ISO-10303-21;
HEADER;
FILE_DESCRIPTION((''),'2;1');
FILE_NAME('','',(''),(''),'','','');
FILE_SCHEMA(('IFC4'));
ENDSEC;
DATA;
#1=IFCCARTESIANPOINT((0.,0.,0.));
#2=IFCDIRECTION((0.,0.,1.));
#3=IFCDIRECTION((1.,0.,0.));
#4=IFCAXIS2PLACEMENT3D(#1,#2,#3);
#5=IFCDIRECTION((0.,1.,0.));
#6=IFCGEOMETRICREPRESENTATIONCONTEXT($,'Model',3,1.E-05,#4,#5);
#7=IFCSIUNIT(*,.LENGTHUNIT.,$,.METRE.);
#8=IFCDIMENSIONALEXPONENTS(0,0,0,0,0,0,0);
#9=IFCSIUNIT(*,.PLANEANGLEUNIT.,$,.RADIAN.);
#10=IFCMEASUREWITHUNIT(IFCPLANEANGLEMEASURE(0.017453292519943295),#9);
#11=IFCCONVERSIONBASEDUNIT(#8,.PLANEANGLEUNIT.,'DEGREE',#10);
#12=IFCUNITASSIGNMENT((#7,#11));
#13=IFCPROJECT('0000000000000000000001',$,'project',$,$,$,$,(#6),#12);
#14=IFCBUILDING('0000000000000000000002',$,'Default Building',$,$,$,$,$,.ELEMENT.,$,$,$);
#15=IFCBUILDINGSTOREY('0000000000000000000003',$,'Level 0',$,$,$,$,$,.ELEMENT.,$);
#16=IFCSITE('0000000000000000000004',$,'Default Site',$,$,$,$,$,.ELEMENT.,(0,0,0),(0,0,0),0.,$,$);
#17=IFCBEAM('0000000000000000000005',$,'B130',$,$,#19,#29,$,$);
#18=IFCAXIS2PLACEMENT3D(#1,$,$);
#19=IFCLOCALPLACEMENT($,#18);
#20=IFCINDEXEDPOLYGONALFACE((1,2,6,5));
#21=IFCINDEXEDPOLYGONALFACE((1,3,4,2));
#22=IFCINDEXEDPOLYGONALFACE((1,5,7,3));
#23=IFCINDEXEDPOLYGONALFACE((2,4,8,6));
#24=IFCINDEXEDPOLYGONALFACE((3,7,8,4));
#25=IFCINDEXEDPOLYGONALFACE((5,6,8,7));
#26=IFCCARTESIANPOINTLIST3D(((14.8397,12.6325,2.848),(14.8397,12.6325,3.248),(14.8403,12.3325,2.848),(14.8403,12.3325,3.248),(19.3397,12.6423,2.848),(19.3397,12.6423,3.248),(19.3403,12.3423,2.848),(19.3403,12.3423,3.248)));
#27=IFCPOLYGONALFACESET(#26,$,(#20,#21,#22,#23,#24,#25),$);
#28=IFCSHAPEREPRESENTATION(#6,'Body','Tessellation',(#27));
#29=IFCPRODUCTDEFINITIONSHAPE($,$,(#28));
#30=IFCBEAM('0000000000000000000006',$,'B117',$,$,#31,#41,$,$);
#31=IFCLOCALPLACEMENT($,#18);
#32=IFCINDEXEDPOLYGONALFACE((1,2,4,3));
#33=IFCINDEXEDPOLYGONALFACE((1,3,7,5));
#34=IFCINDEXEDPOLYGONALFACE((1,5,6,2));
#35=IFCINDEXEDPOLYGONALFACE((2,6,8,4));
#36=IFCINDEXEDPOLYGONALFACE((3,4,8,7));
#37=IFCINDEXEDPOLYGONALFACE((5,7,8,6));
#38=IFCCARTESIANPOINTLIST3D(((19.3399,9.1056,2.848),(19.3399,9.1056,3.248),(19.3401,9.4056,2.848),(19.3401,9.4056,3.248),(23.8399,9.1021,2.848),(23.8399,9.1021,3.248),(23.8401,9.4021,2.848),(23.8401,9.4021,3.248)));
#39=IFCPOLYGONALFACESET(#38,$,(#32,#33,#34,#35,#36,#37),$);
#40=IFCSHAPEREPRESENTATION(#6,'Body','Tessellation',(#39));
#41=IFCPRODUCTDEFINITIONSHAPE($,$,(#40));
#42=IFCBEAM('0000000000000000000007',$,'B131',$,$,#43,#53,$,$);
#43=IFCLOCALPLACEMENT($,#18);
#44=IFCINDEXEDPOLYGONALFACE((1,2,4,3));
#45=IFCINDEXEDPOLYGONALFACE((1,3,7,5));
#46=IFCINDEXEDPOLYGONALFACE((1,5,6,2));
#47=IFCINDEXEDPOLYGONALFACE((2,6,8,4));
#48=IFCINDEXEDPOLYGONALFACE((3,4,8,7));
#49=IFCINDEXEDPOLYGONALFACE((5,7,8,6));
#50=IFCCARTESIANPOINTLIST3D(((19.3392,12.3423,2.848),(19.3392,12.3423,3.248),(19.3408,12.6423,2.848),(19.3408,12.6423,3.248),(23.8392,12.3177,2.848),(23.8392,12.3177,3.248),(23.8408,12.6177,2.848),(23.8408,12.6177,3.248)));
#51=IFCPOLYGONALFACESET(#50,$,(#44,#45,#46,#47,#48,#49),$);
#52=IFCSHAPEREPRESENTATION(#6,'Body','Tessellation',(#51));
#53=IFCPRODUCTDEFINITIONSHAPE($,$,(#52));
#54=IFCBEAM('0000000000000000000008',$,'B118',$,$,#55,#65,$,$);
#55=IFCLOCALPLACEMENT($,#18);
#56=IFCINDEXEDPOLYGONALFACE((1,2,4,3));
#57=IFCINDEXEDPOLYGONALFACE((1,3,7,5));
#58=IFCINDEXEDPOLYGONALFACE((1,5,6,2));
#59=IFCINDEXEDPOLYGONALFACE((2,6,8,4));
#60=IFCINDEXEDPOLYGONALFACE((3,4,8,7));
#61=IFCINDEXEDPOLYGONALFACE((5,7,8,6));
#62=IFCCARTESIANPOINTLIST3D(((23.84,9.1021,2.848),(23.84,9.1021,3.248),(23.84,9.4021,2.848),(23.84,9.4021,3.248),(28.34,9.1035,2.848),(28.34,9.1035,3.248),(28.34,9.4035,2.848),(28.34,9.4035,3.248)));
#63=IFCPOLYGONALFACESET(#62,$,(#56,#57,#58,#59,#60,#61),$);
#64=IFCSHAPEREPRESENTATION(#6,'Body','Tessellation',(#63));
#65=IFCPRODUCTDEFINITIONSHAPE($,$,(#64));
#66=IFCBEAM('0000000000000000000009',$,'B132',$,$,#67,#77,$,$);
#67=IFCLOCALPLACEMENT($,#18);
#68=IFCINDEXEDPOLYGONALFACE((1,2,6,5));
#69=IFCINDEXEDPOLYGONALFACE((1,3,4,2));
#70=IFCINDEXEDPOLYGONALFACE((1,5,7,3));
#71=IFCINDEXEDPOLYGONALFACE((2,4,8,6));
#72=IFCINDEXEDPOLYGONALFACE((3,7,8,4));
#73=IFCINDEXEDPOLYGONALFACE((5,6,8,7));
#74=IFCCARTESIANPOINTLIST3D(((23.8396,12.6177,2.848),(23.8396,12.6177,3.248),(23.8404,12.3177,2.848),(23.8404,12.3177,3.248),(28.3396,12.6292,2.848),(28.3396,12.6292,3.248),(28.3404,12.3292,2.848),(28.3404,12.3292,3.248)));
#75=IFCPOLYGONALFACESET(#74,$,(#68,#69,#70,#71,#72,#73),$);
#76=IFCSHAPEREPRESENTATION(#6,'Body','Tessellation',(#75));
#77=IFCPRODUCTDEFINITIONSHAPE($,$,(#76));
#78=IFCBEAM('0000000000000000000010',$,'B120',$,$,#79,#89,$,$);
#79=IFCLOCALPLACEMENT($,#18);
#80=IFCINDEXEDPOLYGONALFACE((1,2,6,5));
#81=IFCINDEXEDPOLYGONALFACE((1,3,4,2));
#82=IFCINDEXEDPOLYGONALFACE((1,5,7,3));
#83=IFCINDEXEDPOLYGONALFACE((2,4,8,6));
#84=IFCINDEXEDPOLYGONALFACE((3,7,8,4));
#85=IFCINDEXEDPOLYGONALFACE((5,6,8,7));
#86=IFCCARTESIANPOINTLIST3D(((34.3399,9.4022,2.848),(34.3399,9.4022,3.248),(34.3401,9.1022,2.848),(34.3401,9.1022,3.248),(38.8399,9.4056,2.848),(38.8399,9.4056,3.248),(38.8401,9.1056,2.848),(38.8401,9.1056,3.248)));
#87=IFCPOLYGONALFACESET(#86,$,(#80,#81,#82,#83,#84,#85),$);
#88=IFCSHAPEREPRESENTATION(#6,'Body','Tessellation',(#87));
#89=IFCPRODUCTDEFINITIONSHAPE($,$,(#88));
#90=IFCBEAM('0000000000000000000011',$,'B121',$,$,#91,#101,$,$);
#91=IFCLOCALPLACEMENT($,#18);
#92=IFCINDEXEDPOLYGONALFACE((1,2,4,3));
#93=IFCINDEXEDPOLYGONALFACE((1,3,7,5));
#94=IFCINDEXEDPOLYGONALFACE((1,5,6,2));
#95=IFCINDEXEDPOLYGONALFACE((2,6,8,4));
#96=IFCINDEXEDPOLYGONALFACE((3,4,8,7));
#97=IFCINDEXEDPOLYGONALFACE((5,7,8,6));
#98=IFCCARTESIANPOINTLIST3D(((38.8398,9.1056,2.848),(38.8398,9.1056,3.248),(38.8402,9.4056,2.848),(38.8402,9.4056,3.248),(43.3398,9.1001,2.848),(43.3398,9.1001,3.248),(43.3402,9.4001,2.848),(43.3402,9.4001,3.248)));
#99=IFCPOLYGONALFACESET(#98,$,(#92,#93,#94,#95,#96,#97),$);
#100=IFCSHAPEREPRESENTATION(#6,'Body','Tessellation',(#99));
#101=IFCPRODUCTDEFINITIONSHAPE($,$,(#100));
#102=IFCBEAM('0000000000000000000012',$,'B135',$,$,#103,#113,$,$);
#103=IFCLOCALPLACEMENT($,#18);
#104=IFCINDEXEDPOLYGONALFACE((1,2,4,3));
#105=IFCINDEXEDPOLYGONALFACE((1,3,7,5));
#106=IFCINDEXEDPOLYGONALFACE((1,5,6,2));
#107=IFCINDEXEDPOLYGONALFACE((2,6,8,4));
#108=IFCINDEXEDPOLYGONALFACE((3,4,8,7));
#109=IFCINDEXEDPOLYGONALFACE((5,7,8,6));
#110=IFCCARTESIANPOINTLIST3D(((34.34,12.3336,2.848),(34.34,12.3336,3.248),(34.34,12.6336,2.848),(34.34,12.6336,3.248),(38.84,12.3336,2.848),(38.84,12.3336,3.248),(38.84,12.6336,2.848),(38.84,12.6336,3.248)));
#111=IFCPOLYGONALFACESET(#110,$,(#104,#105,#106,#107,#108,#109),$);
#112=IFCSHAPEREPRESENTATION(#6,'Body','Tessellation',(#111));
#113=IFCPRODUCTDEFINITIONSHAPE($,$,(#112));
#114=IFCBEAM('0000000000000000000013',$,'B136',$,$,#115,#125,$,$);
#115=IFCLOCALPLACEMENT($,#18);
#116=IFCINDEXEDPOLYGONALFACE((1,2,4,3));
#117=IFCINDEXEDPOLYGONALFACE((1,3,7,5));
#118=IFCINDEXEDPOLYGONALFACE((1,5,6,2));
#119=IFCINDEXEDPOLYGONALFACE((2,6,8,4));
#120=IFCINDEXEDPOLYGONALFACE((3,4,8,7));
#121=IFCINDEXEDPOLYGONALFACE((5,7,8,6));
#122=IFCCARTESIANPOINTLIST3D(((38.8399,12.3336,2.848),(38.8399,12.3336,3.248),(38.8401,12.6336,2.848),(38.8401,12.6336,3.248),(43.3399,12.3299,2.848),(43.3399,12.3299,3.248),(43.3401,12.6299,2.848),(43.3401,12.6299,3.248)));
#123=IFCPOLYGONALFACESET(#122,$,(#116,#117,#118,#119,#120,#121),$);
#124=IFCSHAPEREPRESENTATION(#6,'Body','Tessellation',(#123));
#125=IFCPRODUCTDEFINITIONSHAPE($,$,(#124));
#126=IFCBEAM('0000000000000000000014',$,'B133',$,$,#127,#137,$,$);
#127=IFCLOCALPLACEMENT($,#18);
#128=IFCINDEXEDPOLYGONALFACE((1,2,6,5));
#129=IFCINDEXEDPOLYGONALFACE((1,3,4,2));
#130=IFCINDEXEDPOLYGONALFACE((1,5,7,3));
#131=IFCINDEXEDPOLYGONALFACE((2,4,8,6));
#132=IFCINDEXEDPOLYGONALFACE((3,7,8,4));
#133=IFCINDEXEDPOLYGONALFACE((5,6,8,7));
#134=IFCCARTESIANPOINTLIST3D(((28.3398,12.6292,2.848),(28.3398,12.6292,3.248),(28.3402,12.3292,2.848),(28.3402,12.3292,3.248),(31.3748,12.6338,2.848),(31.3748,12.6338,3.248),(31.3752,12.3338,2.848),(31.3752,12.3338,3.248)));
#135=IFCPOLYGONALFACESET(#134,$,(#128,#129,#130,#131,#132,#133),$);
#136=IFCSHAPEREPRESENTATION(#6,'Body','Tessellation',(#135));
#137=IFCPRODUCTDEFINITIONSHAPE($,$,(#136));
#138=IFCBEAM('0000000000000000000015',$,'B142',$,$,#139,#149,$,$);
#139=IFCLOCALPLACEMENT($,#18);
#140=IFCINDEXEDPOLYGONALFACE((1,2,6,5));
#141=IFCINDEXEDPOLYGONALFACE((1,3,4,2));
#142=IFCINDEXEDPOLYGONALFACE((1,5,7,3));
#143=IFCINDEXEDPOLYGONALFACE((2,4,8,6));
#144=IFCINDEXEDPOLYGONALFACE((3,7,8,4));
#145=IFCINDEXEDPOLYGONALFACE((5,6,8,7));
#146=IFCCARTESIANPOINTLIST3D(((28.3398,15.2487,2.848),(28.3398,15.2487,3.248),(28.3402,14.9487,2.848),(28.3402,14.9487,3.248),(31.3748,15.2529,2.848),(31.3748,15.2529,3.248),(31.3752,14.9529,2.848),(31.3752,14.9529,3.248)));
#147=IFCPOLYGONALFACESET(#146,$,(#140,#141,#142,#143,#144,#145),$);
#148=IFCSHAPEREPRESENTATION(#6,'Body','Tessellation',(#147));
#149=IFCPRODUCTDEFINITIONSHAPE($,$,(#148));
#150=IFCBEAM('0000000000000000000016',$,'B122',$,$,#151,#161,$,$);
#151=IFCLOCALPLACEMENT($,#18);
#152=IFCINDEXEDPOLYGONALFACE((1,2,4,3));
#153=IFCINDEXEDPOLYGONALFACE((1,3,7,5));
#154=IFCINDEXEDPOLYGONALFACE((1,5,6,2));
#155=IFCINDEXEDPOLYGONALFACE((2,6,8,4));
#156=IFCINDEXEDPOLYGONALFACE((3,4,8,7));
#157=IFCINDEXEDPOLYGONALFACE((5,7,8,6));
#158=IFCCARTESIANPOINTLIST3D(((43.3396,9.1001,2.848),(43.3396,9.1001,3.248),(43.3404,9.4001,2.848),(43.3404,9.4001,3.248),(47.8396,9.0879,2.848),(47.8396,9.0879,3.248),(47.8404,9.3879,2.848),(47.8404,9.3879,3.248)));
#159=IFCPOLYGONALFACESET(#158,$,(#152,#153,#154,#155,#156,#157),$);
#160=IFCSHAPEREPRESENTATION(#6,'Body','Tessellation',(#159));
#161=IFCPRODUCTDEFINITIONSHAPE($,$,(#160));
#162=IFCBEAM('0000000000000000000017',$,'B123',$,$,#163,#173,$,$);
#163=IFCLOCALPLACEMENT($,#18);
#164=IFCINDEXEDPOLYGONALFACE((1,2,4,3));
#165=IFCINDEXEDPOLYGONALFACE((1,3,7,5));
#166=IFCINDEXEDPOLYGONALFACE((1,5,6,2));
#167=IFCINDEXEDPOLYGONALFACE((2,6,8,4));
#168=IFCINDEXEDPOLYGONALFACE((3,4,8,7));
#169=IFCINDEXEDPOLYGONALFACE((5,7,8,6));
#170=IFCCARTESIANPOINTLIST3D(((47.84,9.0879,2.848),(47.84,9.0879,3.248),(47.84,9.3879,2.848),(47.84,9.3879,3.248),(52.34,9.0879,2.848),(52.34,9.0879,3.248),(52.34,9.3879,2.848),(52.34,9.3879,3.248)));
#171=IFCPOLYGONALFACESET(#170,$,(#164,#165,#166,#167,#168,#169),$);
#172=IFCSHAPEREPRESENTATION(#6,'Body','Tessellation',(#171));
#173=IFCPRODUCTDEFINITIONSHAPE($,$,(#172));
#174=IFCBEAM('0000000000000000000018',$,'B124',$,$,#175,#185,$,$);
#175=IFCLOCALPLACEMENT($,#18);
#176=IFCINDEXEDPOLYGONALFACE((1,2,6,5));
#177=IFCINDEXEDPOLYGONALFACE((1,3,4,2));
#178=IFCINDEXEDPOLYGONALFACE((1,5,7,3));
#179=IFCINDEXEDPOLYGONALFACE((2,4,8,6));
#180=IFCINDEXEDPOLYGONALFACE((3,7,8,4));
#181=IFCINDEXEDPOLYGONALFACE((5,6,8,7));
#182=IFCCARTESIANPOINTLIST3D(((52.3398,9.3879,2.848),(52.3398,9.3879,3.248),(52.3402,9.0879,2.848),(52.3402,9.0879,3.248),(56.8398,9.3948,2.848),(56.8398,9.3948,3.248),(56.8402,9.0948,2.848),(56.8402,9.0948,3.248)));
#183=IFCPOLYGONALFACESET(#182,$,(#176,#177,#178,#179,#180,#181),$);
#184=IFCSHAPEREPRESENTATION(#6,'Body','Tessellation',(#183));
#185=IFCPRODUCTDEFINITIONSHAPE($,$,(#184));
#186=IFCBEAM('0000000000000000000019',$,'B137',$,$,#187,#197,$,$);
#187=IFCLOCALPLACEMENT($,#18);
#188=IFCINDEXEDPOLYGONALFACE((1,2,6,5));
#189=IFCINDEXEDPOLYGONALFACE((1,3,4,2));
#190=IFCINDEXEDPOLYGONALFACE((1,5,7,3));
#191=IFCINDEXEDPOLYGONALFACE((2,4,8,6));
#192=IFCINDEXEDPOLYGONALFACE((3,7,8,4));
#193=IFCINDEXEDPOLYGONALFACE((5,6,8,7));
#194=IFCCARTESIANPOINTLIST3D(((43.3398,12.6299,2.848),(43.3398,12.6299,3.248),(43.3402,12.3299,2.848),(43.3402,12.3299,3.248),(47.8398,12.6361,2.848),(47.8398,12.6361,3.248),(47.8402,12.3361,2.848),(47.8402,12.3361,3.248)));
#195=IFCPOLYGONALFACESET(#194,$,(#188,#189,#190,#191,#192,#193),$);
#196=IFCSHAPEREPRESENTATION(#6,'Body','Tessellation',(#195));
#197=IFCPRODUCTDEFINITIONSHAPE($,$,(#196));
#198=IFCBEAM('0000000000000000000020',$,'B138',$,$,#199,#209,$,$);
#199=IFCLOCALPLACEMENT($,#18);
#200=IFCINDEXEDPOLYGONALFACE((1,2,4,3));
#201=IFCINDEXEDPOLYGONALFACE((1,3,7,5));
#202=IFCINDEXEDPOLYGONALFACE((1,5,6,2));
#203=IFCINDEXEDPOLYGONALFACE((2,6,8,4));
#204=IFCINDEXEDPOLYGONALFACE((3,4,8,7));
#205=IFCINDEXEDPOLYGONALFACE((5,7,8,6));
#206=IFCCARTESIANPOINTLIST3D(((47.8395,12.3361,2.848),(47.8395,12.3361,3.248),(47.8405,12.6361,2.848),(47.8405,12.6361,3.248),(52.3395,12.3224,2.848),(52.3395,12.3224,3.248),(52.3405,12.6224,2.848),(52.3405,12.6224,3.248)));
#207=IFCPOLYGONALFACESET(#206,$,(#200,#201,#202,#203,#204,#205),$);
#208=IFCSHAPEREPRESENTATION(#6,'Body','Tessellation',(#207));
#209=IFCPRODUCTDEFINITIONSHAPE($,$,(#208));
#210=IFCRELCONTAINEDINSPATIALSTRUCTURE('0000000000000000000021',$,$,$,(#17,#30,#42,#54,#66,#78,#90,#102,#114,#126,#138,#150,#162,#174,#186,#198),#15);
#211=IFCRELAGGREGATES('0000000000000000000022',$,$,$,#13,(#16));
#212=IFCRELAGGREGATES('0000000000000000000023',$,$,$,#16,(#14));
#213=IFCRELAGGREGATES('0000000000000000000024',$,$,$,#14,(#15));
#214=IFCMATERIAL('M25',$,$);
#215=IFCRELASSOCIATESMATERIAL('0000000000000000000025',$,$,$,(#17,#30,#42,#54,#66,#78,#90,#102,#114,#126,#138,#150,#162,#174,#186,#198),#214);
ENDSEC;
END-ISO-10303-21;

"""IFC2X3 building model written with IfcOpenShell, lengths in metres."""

from ifc_helpers import new_model, entity, si_unit, converted_unit, direction, frame, frame_2d, origin_with_axes, place, context, project, spatial, rectangle, extrude, material, element, save


model = new_model("IFC2X3")

# Units and contexts
model_context = context("Model", 3, precision=1e-05, world=origin_with_axes(), true_north=direction((0.0, 1.0, 0.0)))
ifc_project = project(units=[si_unit("LENGTHUNIT", "METRE"), converted_unit("PLANEANGLEUNIT", "DEGREE", entity("IfcPlaneAngleMeasure", 0.017453292519943295), si_unit("PLANEANGLEUNIT", "RADIAN"), dimensions=[0, 0, 0, 0, 0, 0, 0])], contexts=[model_context])

# Site, building, storey
site = spatial("IfcSite", under=ifc_project, Name="Default Site", CompositionType="ELEMENT", RefLatitude=(0, 0, 0), RefLongitude=(0, 0, 0), RefElevation=0.0)
building = spatial("IfcBuilding", under=site, Name="Default Building", CompositionType="ELEMENT")
storey = spatial("IfcBuildingStorey", under=building, Name="Level 0", CompositionType="ELEMENT")

# Beams
ifc_material = material(Name="M25")
placement = place(None, origin_with_axes())
element("IfcBeam", 1, at=placement, inside=storey, material=ifc_material, Name="B130", context=model_context, shape_type="SweptSolid", body=[
    extrude(rectangle(XDim=0.3, YDim=0.4, at=frame_2d((0.0, 0.0), x_axis=(0.0, 1.0, 0.0))), frame((14.84, 12.4825, 3.048), z_axis=(0.999998, 0.002176, 0.0), x_axis=(0.0, 0.0, -1.0)), (0.0, 0.0, 1.0), 4.5),
])
element("IfcBeam", 2, at=placement, inside=storey, material=ifc_material, Name="B117", context=model_context, shape_type="SweptSolid", body=[
    extrude(rectangle(XDim=0.3, YDim=0.4, at=frame_2d((0.0, 0.0), x_axis=(0.0, 1.0, 0.0))), frame((19.34, 9.2556, 3.048), z_axis=(1.0, -0.000779, 0.0), x_axis=(0.0, 0.0, -1.0)), (0.0, 0.0, 1.0), 4.5),
])
element("IfcBeam", 3, at=placement, inside=storey, material=ifc_material, Name="B131", context=model_context, shape_type="SweptSolid", body=[
    extrude(rectangle(XDim=0.3, YDim=0.4, at=frame_2d((0.0, 0.0), x_axis=(0.0, 1.0, 0.0))), frame((19.34, 12.4923, 3.048), z_axis=(0.999985, -0.005463, 0.0), x_axis=(0.0, 0.0, -1.0)), (0.0, 0.0, 1.0), 4.5001),
])
element("IfcBeam", 4, at=placement, inside=storey, material=ifc_material, Name="B118", context=model_context, shape_type="SweptSolid", body=[
    extrude(rectangle(XDim=0.3, YDim=0.4, at=frame_2d((0.0, 0.0), x_axis=(0.0, 1.0, 0.0))), frame((23.84, 9.2521, 3.048), z_axis=(1.0, 0.000307, 0.0), x_axis=(0.0, 0.0, -1.0)), (0.0, 0.0, 1.0), 4.5),
])
element("IfcBeam", 5, at=placement, inside=storey, material=ifc_material, Name="B132", context=model_context, shape_type="SweptSolid", body=[
    extrude(rectangle(XDim=0.3, YDim=0.4, at=frame_2d((0.0, 0.0), x_axis=(0.0, 1.0, 0.0))), frame((23.84, 12.4677, 3.048), z_axis=(0.999997, 0.002551, 0.0), x_axis=(0.0, 0.0, -1.0)), (0.0, 0.0, 1.0), 4.5),
])
element("IfcBeam", 6, at=placement, inside=storey, material=ifc_material, Name="B120", context=model_context, shape_type="SweptSolid", body=[
    extrude(rectangle(XDim=0.3, YDim=0.4, at=frame_2d((0.0, 0.0), x_axis=(0.0, 1.0, 0.0))), frame((34.34, 9.2522, 3.048), z_axis=(1.0, 0.000748, 0.0), x_axis=(0.0, 0.0, -1.0)), (0.0, 0.0, 1.0), 4.5),
])
element("IfcBeam", 7, at=placement, inside=storey, material=ifc_material, Name="B121", context=model_context, shape_type="SweptSolid", body=[
    extrude(rectangle(XDim=0.3, YDim=0.4, at=frame_2d((0.0, 0.0), x_axis=(0.0, 1.0, 0.0))), frame((38.84, 9.2556, 3.048), z_axis=(0.999999, -0.001227, 0.0), x_axis=(0.0, 0.0, -1.0)), (0.0, 0.0, 1.0), 4.5),
])
element("IfcBeam", 8, at=placement, inside=storey, material=ifc_material, Name="B135", context=model_context, shape_type="SweptSolid", body=[
    extrude(rectangle(XDim=0.3, YDim=0.4, at=frame_2d((0.0, 0.0), x_axis=(0.0, 1.0, 0.0))), frame((34.34, 12.4836, 3.048), z_axis=(1.0, -0.000008, 0.0), x_axis=(0.0, 0.0, -1.0)), (0.0, 0.0, 1.0), 4.5),
])
element("IfcBeam", 9, at=placement, inside=storey, material=ifc_material, Name="B136", context=model_context, shape_type="SweptSolid", body=[
    extrude(rectangle(XDim=0.3, YDim=0.4, at=frame_2d((0.0, 0.0), x_axis=(0.0, 1.0, 0.0))), frame((38.84, 12.4836, 3.048), z_axis=(1.0, -0.000826, 0.0), x_axis=(0.0, 0.0, -1.0)), (0.0, 0.0, 1.0), 4.5),
])
element("IfcBeam", 10, at=placement, inside=storey, material=ifc_material, Name="B133", context=model_context, shape_type="SweptSolid", body=[
    extrude(rectangle(XDim=0.3, YDim=0.4, at=frame_2d((0.0, 0.0), x_axis=(0.0, 1.0, 0.0))), frame((28.34, 12.4792, 3.048), z_axis=(0.999999, 0.001542, 0.0), x_axis=(0.0, 0.0, -1.0)), (0.0, 0.0, 1.0), 3.035),
])
element("IfcBeam", 11, at=placement, inside=storey, material=ifc_material, Name="B142", context=model_context, shape_type="SweptSolid", body=[
    extrude(rectangle(XDim=0.3, YDim=0.4, at=frame_2d((0.0, 0.0), x_axis=(0.0, 1.0, 0.0))), frame((31.375, 15.1029, 3.048), z_axis=(-0.999999, -0.001391, 0.0), x_axis=(0.0, 0.0, -1.0)), (0.0, 0.0, 1.0), 3.035),
])
element("IfcBeam", 12, at=placement, inside=storey, material=ifc_material, Name="B122", context=model_context, shape_type="SweptSolid", body=[
    extrude(rectangle(XDim=0.3, YDim=0.4, at=frame_2d((0.0, 0.0), x_axis=(0.0, 1.0, 0.0))), frame((43.34, 9.2501, 3.048), z_axis=(0.999996, -0.002702, 0.0), x_axis=(0.0, 0.0, -1.0)), (0.0, 0.0, 1.0), 4.5),
])
element("IfcBeam", 13, at=placement, inside=storey, material=ifc_material, Name="B123", context=model_context, shape_type="SweptSolid", body=[
    extrude(rectangle(XDim=0.3, YDim=0.4, at=frame_2d((0.0, 0.0), x_axis=(0.0, 1.0, 0.0))), frame((47.84, 9.2379, 3.048), z_axis=(1.0, 0.0, 0.0), x_axis=(0.0, 0.0, -1.0)), (0.0, 0.0, 1.0), 4.5),
])
element("IfcBeam", 14, at=placement, inside=storey, material=ifc_material, Name="B124", context=model_context, shape_type="SweptSolid", body=[
    extrude(rectangle(XDim=0.3, YDim=0.4, at=frame_2d((0.0, 0.0), x_axis=(0.0, 1.0, 0.0))), frame((52.34, 9.2379, 3.048), z_axis=(0.999999, 0.001537, 0.0), x_axis=(0.0, 0.0, -1.0)), (0.0, 0.0, 1.0), 4.5),
])
element("IfcBeam", 15, at=placement, inside=storey, material=ifc_material, Name="B137", context=model_context, shape_type="SweptSolid", body=[
    extrude(rectangle(XDim=0.3, YDim=0.4, at=frame_2d((0.0, 0.0), x_axis=(0.0, 1.0, 0.0))), frame((43.34, 12.4799, 3.048), z_axis=(0.999999, 0.001374, 0.0), x_axis=(0.0, 0.0, -1.0)), (0.0, 0.0, 1.0), 4.5),
])
element("IfcBeam", 16, at=placement, inside=storey, material=ifc_material, Name="B138", context=model_context, shape_type="SweptSolid", body=[
    extrude(rectangle(XDim=0.3, YDim=0.4, at=frame_2d((0.0, 0.0), x_axis=(0.0, 1.0, 0.0))), frame((47.84, 12.4861, 3.048), z_axis=(0.999995, -0.003045, 0.0), x_axis=(0.0, 0.0, -1.0)), (0.0, 0.0, 1.0), 4.5),
])

save(model, "model.ifc")
